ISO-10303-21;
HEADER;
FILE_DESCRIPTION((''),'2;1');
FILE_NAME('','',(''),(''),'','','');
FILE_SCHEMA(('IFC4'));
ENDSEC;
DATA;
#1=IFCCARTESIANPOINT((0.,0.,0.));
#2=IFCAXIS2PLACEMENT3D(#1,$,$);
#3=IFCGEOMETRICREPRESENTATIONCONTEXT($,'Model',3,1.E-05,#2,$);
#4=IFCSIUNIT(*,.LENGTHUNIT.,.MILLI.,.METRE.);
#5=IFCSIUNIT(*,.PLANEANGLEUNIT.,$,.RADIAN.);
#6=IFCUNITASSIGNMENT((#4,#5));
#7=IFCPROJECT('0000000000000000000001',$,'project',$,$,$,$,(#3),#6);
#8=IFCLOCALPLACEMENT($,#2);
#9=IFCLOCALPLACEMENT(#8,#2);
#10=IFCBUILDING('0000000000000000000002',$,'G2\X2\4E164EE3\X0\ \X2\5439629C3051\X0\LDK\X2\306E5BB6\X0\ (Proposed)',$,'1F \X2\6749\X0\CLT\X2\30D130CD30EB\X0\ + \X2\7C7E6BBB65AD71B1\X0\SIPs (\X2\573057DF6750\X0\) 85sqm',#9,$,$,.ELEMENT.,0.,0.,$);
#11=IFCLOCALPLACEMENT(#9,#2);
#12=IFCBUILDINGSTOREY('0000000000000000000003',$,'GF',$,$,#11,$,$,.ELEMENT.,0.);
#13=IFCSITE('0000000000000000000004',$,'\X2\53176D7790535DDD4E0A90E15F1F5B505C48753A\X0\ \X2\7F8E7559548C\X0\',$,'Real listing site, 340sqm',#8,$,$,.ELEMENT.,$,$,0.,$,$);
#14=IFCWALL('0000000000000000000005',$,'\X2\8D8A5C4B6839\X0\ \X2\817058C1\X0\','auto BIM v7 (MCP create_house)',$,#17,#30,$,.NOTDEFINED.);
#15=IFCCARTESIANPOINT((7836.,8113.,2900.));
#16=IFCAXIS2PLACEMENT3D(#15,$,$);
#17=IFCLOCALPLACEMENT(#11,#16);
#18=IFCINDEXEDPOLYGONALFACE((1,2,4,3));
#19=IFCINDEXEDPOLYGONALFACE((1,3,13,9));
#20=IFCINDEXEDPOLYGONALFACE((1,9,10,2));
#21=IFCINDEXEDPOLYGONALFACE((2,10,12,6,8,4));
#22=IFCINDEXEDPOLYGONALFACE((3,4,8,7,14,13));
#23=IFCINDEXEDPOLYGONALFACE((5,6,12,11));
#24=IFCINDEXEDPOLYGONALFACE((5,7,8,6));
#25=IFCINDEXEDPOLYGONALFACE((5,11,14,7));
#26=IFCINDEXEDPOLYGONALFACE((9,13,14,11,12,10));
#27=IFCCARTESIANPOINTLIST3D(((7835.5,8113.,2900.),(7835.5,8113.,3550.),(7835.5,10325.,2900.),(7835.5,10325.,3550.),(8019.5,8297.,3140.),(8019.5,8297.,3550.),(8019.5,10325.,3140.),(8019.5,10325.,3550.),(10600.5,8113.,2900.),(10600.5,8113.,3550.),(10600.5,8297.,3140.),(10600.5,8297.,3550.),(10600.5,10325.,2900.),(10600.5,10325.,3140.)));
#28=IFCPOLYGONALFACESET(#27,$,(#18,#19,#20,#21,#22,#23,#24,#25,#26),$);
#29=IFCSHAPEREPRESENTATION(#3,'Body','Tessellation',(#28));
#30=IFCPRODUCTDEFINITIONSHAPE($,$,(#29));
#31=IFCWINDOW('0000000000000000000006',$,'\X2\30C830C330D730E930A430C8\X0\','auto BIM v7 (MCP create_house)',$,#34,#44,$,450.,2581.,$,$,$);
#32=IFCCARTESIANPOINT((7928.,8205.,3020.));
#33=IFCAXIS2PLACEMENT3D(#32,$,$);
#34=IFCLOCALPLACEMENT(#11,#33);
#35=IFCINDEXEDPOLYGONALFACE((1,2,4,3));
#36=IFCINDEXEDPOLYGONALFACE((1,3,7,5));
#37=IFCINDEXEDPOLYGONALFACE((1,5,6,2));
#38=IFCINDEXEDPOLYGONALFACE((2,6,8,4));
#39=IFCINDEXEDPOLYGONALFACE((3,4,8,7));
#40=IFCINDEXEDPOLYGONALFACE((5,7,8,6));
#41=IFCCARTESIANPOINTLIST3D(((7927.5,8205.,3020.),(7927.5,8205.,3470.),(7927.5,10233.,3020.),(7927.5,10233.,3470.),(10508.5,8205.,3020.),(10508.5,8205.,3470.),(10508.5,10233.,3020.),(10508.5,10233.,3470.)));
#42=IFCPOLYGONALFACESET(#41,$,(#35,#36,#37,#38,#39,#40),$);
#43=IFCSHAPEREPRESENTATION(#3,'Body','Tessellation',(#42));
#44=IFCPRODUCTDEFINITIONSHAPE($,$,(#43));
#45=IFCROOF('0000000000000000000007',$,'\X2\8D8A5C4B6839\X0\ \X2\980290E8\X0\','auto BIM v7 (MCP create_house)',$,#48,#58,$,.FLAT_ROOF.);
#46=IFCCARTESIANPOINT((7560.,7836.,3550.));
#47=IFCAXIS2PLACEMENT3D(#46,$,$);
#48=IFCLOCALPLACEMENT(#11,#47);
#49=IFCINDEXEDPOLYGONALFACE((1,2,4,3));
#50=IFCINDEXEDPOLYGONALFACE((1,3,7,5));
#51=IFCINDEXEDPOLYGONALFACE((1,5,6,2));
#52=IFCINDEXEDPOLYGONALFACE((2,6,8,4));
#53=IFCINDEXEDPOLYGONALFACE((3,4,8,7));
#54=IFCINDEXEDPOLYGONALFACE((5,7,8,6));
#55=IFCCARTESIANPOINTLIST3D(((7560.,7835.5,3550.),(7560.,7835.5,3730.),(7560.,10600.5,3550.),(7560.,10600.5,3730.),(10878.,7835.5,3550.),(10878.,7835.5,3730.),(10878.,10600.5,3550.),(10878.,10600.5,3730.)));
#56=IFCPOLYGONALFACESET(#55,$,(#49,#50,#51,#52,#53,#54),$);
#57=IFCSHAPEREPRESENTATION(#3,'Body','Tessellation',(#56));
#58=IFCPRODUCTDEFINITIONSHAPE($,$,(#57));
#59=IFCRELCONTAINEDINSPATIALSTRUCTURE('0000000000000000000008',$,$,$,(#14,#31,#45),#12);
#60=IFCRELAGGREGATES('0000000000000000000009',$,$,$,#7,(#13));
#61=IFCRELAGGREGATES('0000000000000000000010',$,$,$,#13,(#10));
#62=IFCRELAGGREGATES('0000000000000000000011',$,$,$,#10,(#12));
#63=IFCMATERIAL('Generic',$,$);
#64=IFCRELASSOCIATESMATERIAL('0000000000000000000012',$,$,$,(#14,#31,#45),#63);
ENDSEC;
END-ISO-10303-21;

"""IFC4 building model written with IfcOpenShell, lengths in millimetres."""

from ifc_helpers import new_model, si_unit, frame, frame_2d, origin, place, context, project, spatial, rectangle, extrude, material, element, fill, save


model = new_model("IFC4")

# Units and contexts
model_context = context("Model", 3, precision=1e-05, world=origin())
ifc_project = project(units=[si_unit("LENGTHUNIT", "METRE", prefix="MILLI"), si_unit("PLANEANGLEUNIT", "RADIAN")], contexts=[model_context])

# Site, building, storey
site_placement = place(None, origin())
site = spatial("IfcSite", under=ifc_project, at=site_placement, Name="北海道川上郡弟子屈町 美留和", ObjectType="Real listing site, 340sqm", CompositionType="ELEMENT", RefElevation=0.0)
building_placement = place(site_placement, origin())
building = spatial("IfcBuilding", under=site, at=building_placement, Name="G2世代 吹抜けLDKの家 (Proposed)", ObjectType="1F 杉CLTパネル + 籾殻断熱SIPs (地域材) 85sqm", CompositionType="ELEMENT", ElevationOfRefHeight=0.0, ElevationOfTerrain=0.0)
storey_placement = place(building_placement, origin())
storey = spatial("IfcBuildingStorey", under=building, at=storey_placement, Name="GF", CompositionType="ELEMENT", Elevation=0.0)

# Shared definitions
ifc_material = material(Name="Generic")

# Wall, opening, window
wall_1_placement = place(storey_placement, frame((7836.0, 8113.0, 2900.0)))
wall_1 = element("IfcWall", 1, at=wall_1_placement, inside=storey, material=ifc_material, Name="越屋根 腰壁", Description="auto BIM v7 (MCP create_house)", PredefinedType="NOTDEFINED", context=model_context, shape_type="SweptSolid", body=[
    extrude(rectangle(XDim=2765.0, YDim=2212.0, at=frame_2d((1382.0, 1106.0))), frame((7836.0, 8113.0, 2900.0)), (0.0, 0.0, 1.0), 650.0),
])
opening_1_placement = place(storey_placement, frame((7928.0, 8205.0, 3020.0)))
opening_1 = element("IfcOpeningElement", 2, at=opening_1_placement, cuts=wall_1, PredefinedType="NOTDEFINED", context=model_context, shape_type="SweptSolid", body=[
    extrude(rectangle(XDim=2581.0, YDim=2028.0, at=frame_2d((1290.0, 1014.0))), frame((7928.0, 8205.0, 3020.0)), (0.0, 0.0, 1.0), 450.0),
])
window_1_placement = place(storey_placement, frame((7928.0, 8205.0, 3020.0)))
window_1 = element("IfcWindow", 3, at=window_1_placement, inside=storey, material=ifc_material, Name="トップライト", Description="auto BIM v7 (MCP create_house)", OverallHeight=450.0, OverallWidth=2581.0, context=model_context, shape_type="SweptSolid", body=[
    extrude(rectangle(XDim=2581.0, YDim=2028.0, at=frame_2d((1290.0, 1014.0))), frame((7928.0, 8205.0, 3020.0)), (0.0, 0.0, 1.0), 450.0),
])
fill(opening_1, window_1)

# Roof
roof_1_placement = place(storey_placement, frame((7560.0, 7836.0, 3550.0)))
element("IfcRoof", 4, at=roof_1_placement, inside=storey, material=ifc_material, Name="越屋根 頂部", Description="auto BIM v7 (MCP create_house)", PredefinedType="FLAT_ROOF", context=model_context, shape_type="SweptSolid", body=[
    extrude(rectangle(XDim=3318.0, YDim=2765.0, at=frame_2d((1659.0, 1382.0))), frame((7560.0, 7836.0, 3550.0)), (0.0, 0.0, 1.0), 180.0),
])

save(model, "model.ifc")
